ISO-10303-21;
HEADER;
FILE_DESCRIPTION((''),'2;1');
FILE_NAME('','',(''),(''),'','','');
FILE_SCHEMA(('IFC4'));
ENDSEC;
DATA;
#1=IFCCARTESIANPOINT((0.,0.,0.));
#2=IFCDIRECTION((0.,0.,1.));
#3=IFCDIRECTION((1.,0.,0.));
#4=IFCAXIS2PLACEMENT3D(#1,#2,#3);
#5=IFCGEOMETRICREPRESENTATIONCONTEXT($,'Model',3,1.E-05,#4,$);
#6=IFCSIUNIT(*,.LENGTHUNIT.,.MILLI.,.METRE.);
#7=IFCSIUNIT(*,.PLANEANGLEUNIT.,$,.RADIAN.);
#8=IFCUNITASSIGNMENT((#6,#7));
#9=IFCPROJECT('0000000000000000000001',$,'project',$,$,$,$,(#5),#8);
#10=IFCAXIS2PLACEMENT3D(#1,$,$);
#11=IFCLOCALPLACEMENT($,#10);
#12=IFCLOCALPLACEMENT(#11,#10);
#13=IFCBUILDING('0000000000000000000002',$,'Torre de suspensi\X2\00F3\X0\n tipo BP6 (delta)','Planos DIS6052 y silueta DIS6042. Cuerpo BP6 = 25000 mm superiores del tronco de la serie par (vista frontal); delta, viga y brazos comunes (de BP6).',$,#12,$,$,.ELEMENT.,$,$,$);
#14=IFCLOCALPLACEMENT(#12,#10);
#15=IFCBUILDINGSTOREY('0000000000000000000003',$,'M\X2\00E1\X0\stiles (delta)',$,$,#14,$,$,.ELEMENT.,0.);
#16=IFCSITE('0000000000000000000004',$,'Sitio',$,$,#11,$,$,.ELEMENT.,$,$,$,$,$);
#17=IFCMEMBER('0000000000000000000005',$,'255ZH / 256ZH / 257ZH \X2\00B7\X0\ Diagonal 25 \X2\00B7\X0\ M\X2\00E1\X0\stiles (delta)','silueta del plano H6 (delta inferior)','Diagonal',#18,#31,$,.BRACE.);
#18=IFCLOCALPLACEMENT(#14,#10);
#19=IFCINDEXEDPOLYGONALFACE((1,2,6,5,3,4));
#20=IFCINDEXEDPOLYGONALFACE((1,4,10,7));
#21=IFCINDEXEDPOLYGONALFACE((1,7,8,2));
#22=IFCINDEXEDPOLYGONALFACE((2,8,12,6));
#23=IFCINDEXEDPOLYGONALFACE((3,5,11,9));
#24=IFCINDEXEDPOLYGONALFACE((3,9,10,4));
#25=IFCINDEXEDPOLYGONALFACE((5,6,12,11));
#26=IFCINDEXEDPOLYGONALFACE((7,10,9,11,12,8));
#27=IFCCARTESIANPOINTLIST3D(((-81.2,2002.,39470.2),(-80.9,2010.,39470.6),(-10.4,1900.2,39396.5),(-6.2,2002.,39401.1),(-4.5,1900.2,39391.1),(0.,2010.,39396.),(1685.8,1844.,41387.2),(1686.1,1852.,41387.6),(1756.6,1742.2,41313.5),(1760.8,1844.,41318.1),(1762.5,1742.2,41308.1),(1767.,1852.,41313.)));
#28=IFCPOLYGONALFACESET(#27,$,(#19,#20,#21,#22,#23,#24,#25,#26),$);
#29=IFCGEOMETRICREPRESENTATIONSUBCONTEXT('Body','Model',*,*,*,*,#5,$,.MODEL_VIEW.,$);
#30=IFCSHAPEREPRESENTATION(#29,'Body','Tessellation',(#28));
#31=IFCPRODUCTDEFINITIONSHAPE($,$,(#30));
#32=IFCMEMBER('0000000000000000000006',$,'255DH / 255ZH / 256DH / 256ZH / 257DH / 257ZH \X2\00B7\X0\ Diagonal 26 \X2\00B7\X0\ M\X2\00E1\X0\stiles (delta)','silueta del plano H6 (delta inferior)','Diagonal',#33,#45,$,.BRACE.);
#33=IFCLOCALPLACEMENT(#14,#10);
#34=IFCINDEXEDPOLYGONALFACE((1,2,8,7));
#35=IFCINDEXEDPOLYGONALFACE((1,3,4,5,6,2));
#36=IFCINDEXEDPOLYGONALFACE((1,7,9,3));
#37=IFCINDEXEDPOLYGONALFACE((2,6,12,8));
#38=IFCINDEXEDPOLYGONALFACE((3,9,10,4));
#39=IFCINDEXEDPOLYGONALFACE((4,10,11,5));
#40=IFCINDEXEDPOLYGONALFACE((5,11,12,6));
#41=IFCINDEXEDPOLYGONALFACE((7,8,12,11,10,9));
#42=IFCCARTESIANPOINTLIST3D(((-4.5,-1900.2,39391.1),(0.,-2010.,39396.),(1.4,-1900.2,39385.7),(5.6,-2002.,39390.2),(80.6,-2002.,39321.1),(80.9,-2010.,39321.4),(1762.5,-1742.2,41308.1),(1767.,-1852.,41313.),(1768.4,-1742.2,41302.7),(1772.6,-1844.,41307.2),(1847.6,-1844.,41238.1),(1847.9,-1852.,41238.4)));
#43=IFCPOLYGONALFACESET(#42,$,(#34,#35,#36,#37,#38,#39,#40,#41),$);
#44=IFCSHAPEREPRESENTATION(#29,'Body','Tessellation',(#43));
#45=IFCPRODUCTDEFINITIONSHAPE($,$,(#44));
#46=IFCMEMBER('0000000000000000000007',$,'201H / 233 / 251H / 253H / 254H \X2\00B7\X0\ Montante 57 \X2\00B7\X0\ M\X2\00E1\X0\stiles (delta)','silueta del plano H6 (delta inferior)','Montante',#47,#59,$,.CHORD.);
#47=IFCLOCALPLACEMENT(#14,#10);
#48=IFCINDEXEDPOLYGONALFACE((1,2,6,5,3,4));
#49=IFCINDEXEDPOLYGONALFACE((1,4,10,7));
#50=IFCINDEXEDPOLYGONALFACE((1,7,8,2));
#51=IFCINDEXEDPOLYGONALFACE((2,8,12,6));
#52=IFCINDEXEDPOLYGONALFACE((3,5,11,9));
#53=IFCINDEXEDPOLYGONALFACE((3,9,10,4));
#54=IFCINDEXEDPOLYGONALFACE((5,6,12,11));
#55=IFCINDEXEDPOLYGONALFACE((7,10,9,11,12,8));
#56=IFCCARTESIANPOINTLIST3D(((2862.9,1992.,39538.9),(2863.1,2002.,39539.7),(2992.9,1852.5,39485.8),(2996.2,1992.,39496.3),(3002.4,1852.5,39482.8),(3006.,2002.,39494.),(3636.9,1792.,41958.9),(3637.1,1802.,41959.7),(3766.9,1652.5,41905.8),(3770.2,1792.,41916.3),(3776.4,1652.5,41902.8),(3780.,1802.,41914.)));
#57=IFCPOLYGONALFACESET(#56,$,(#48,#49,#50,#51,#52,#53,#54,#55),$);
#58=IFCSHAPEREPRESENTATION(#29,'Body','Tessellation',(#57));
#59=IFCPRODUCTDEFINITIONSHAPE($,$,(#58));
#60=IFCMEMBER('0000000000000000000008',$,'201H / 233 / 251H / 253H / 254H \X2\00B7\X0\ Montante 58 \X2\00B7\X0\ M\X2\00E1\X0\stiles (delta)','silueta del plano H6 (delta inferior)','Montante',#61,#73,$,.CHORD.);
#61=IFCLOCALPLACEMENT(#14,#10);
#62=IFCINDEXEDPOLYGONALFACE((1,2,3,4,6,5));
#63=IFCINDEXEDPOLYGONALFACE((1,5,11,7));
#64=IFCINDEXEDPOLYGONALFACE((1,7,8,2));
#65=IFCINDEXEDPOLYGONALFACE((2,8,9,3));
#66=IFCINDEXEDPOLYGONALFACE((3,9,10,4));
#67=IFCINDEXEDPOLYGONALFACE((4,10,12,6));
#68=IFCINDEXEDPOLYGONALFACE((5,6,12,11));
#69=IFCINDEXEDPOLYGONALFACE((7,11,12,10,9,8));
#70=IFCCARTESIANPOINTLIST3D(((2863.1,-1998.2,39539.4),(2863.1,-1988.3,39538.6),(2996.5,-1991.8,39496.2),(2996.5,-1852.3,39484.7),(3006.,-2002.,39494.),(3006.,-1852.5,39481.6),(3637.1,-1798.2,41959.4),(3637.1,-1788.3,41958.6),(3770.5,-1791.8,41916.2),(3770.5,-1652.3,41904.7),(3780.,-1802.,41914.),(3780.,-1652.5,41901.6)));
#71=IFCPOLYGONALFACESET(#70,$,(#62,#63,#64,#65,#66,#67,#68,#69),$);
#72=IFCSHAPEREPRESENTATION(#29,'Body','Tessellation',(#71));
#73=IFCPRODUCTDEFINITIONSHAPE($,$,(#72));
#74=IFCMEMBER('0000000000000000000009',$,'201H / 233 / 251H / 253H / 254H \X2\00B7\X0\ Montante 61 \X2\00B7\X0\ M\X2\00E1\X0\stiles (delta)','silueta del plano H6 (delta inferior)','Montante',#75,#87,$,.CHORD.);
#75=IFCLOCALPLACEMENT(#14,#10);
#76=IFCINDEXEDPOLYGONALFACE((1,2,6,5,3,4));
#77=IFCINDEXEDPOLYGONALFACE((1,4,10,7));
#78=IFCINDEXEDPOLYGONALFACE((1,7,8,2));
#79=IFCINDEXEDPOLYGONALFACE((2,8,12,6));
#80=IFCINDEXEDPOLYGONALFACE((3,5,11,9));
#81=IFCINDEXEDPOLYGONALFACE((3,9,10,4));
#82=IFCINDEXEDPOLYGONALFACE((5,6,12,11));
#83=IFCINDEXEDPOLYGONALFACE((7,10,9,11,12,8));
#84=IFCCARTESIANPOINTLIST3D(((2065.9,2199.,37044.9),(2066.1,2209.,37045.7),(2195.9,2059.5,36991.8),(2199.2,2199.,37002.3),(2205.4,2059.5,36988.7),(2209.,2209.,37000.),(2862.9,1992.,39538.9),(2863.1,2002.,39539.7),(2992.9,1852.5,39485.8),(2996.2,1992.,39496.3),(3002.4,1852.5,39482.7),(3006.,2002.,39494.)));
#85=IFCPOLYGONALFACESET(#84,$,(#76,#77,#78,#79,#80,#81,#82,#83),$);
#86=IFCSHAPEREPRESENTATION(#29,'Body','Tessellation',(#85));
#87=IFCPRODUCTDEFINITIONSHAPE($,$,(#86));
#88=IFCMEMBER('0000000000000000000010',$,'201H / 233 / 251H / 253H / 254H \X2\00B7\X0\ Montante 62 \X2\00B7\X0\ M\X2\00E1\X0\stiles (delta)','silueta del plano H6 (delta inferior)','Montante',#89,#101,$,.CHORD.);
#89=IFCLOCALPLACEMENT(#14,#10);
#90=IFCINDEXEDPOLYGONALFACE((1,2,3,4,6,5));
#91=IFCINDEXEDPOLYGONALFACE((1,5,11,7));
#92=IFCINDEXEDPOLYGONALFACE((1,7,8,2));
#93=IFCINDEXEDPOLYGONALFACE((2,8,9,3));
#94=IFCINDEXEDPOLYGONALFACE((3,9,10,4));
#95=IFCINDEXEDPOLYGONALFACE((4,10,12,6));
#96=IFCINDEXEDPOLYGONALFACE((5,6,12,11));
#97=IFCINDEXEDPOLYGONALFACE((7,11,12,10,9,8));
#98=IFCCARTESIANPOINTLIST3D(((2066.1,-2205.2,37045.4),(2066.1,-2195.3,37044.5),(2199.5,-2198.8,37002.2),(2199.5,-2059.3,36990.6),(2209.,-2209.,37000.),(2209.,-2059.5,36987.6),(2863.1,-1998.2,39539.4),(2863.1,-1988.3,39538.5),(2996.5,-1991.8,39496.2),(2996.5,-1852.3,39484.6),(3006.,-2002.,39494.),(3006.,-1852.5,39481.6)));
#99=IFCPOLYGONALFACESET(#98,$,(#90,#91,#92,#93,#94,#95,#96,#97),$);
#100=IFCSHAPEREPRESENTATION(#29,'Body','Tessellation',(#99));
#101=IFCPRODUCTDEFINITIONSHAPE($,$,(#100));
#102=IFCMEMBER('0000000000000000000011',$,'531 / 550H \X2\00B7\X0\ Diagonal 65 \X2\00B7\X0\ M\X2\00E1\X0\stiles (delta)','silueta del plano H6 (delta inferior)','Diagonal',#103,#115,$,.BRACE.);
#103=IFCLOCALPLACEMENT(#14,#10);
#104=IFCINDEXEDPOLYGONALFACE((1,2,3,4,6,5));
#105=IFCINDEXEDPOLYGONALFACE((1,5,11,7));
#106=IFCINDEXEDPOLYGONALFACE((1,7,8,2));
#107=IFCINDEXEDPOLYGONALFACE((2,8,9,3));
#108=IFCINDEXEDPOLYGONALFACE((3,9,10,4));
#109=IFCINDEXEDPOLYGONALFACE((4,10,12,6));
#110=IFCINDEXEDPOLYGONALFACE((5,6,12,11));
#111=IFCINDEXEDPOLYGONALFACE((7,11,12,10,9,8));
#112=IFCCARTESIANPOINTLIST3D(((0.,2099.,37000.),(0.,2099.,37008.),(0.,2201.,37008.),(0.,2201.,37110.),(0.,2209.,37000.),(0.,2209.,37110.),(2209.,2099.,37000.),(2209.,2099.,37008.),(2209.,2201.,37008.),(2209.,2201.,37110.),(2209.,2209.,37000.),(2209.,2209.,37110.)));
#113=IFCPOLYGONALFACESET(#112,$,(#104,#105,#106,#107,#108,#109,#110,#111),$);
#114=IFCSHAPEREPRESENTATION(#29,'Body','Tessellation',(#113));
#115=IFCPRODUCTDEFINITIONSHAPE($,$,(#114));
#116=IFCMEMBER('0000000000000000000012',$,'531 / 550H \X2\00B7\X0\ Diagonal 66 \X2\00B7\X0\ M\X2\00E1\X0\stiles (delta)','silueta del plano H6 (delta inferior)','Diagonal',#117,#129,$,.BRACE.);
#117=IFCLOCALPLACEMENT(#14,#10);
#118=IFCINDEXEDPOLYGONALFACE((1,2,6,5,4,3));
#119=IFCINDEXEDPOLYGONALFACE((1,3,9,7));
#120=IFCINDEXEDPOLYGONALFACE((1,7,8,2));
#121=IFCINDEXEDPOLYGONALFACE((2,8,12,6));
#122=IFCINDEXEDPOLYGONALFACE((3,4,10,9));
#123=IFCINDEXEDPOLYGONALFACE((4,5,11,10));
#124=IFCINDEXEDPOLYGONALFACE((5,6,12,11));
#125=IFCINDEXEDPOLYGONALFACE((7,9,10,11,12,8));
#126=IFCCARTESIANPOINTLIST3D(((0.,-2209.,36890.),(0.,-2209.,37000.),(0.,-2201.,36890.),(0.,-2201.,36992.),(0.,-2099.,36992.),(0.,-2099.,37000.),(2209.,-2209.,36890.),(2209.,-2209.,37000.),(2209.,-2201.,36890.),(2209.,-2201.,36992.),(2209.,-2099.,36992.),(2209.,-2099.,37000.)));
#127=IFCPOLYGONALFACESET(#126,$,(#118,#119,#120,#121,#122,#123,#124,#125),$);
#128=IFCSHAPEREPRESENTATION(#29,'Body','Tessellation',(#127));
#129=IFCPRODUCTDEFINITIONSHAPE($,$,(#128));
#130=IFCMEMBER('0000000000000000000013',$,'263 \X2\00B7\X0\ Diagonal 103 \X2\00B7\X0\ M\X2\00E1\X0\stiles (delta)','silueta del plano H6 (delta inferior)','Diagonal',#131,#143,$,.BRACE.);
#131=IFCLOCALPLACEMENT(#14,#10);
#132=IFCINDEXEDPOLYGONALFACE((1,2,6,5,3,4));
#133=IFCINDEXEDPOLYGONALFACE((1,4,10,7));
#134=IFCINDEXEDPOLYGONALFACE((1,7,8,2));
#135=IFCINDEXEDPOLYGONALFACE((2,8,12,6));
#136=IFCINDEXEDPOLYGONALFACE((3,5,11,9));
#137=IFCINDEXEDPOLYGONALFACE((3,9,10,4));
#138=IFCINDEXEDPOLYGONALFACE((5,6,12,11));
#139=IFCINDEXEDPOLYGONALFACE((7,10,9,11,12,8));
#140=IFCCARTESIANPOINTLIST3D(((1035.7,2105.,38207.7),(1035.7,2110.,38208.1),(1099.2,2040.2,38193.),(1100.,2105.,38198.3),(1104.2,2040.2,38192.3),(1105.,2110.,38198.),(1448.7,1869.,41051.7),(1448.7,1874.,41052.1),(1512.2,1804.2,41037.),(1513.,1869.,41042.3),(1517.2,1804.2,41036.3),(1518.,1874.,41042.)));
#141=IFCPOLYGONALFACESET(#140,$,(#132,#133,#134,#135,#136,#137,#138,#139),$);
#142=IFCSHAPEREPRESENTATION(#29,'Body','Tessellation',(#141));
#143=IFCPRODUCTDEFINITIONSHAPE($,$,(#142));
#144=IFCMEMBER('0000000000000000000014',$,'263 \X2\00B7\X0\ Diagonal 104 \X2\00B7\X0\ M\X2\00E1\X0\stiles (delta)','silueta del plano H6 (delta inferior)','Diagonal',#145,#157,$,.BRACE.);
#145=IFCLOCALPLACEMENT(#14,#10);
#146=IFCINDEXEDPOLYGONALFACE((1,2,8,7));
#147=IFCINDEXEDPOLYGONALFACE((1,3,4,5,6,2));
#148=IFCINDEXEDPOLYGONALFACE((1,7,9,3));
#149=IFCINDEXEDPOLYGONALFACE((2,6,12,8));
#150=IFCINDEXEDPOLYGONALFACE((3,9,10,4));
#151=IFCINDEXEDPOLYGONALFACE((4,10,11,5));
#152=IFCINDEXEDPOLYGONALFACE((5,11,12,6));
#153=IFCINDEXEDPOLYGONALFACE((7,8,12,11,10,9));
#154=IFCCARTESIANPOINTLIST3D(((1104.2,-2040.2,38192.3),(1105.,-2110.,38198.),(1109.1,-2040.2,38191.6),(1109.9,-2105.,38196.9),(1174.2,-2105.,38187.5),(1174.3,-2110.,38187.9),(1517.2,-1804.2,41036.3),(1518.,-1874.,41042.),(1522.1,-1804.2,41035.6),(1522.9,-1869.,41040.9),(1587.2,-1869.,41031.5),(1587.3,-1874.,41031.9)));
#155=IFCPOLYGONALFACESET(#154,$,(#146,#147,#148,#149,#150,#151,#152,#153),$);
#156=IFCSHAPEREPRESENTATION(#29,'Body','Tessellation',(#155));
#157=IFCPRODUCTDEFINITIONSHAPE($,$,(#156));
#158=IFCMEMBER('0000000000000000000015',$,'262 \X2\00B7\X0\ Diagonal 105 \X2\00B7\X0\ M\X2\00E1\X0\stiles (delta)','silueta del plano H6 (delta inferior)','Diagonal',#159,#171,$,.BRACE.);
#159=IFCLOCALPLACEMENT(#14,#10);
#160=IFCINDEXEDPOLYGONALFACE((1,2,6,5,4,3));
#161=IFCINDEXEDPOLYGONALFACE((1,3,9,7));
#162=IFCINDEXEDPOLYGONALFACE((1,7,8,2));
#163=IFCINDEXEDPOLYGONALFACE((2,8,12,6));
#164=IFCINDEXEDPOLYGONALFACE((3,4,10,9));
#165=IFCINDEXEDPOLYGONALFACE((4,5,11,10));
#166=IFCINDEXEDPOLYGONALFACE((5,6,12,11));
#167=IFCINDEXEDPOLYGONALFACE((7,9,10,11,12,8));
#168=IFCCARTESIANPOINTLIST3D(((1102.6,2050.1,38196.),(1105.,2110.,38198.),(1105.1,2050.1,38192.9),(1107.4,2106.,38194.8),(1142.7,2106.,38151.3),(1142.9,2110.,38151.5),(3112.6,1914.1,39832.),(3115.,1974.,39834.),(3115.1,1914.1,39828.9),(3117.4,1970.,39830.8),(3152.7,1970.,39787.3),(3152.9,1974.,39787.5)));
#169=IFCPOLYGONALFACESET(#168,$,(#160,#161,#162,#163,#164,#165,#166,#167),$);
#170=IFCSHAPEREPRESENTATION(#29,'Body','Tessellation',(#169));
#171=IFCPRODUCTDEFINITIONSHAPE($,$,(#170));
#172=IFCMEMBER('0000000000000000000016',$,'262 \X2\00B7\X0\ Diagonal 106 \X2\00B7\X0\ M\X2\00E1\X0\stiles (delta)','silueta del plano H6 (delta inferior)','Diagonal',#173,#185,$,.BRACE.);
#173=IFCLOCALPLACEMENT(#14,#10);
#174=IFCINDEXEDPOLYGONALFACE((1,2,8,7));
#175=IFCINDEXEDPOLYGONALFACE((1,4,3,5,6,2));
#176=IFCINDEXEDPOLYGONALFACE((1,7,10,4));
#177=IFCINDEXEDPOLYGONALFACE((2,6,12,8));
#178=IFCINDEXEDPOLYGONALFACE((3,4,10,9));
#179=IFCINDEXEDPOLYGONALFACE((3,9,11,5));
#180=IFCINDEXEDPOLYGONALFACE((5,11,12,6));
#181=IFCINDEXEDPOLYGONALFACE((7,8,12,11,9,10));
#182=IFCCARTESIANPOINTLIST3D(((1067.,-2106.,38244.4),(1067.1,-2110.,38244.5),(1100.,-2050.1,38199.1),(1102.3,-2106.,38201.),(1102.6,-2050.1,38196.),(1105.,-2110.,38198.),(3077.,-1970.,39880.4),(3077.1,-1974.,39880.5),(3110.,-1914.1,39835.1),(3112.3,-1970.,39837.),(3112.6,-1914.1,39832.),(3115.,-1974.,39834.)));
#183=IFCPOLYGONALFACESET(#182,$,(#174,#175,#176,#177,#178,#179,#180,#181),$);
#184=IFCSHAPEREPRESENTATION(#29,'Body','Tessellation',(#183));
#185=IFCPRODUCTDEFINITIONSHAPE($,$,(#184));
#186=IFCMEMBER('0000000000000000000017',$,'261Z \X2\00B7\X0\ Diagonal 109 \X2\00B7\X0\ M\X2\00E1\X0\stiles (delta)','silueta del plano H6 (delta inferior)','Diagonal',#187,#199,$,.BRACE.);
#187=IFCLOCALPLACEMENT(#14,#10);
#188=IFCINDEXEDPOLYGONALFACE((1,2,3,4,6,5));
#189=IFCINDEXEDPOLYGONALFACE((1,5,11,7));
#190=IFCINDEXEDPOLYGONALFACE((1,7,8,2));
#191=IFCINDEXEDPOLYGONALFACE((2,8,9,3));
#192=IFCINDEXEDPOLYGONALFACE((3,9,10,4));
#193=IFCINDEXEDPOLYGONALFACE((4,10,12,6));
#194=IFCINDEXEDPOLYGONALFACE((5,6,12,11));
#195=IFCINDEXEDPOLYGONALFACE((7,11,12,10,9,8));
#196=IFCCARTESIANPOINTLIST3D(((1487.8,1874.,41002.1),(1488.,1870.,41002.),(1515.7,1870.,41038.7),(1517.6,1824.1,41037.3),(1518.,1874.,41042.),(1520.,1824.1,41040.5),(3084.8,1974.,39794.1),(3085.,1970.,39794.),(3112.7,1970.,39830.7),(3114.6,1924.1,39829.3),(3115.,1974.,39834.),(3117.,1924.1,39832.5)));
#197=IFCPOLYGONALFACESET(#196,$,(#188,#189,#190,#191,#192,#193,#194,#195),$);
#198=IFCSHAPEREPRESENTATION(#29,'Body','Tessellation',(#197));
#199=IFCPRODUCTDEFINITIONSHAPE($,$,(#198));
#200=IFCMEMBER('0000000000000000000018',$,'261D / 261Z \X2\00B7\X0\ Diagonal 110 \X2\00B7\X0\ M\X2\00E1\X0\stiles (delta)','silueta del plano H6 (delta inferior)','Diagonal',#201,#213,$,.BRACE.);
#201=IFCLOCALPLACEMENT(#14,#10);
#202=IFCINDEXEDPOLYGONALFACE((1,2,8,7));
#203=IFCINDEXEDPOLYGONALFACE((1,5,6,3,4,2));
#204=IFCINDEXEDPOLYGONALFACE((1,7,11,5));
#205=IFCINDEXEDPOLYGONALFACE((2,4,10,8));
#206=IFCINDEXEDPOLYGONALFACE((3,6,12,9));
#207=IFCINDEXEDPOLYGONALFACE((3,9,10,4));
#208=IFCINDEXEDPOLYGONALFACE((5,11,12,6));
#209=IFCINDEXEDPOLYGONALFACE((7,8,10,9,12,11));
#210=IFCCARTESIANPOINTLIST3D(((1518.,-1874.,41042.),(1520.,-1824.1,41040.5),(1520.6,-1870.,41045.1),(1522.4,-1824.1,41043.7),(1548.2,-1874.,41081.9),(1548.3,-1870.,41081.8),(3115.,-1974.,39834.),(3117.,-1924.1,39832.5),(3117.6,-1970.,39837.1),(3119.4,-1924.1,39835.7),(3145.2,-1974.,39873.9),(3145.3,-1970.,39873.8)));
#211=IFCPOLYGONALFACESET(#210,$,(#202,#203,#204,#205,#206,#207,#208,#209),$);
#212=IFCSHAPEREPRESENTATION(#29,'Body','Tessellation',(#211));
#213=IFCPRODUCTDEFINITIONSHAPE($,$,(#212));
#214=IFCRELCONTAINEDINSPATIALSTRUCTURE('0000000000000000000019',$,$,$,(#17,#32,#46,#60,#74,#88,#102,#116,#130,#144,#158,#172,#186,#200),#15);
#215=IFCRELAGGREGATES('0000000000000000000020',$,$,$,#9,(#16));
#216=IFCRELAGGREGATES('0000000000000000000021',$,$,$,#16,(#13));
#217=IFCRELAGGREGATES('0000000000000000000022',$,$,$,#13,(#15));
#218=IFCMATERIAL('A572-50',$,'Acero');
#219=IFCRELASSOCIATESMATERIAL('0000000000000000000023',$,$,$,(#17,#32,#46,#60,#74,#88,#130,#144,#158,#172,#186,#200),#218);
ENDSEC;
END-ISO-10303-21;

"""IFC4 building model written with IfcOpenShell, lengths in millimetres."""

from ifc_helpers import new_model, si_unit, frame, frame_2d, origin, origin_with_axes, place, context, subcontext, project, spatial, l_section, extrude, material, element, save


model = new_model("IFC4")

# Units and contexts
model_context = context("Model", 3, precision=1e-05, world=origin_with_axes())
body_context = subcontext(model_context, "Body", "Model", "MODEL_VIEW")
ifc_project = project(units=[si_unit("LENGTHUNIT", "METRE", prefix="MILLI"), si_unit("PLANEANGLEUNIT", "RADIAN")], contexts=[model_context])

# Site, building, storey
site_placement = place(None, origin())
site = spatial("IfcSite", under=ifc_project, at=site_placement, Name="Sitio", CompositionType="ELEMENT")
building_placement = place(site_placement, origin())
building = spatial("IfcBuilding", under=site, at=building_placement, Name="Torre de suspensión tipo BP6 (delta)", Description="Planos DIS6052 y silueta DIS6042. Cuerpo BP6 = 25000 mm superiores del tronco de la serie par (vista frontal); delta, viga y brazos comunes (de BP6).", CompositionType="ELEMENT")
storey_placement = place(building_placement, origin())
storey = spatial("IfcBuildingStorey", under=building, at=storey_placement, Name="Mástiles (delta)", CompositionType="ELEMENT", Elevation=0.0)

# Members
ifc_material_1 = material(Name="A572-50", Category="Acero")
for number, where, z_axis, x_axis, name in (
    (1, (1767.0, 1852.0, 41313.0), (-0.676513, 0.060492, -0.733942), (-0.040999, -0.998169, -0.044479), "255ZH / 256ZH / 257ZH · Diagonal 25 · Mástiles (delta)"),
    (2, (1767.0, -1852.0, 41313.0), (-0.676513, -0.060492, -0.733942), (-0.040999, 0.998169, -0.044479), "255DH / 255ZH / 256DH / 256ZH / 257DH / 257ZH · Diagonal 26 · Mástiles (delta)"),
):
    element("IfcMember", number, at=place(storey_placement, frame(where, z_axis=z_axis, x_axis=x_axis)), inside=storey, material=ifc_material_1, Name=name, Description="silueta del plano H6 (delta inferior)", ObjectType="Diagonal", PredefinedType="BRACE", context=body_context, shape_type="SweptSolid", body=[
        extrude(l_section(Depth=110.0, Width=110.0, Thickness=8.0, at=frame_2d((55.0, 55.0))), None, (0.0, 0.0, 1.0), 2611.9),
    ])
for number, where, z_axis, x_axis, name in (
    (3, (3780.0, 1802.0, 41914.0), (-0.303693, 0.078474, -0.949533), (-0.023906, -0.996916, -0.074744), "201H / 233 / 251H / 253H / 254H · Montante 57 · Mástiles (delta)"),
    (4, (3780.0, -1802.0, 41914.0), (-0.303693, -0.078474, -0.949533), (-0.95277, 0.025013, 0.302662), "201H / 233 / 251H / 253H / 254H · Montante 58 · Mástiles (delta)"),
):
    element("IfcMember", number, at=place(storey_placement, frame(where, z_axis=z_axis, x_axis=x_axis)), inside=storey, material=ifc_material_1, Name=name, Description="silueta del plano H6 (delta inferior)", ObjectType="Montante", PredefinedType="CHORD", context=body_context, shape_type="SweptSolid", body=[
        extrude(l_section(Depth=150.0, Width=150.0, Thickness=10.0, at=frame_2d((75.0, 75.0))), None, (0.0, 0.0, 1.0), 2548.6),
    ])
for number, where, z_axis, x_axis, name in (
    (5, (3006.0, 2002.0, 39494.0), (-0.303455, 0.078814, -0.949581), (-0.023991, -0.996889, -0.075074), "201H / 233 / 251H / 253H / 254H · Montante 61 · Mástiles (delta)"),
    (6, (3006.0, -2002.0, 39494.0), (-0.303455, -0.078814, -0.949581), (-0.952846, 0.0251, 0.302415), "201H / 233 / 251H / 253H / 254H · Montante 62 · Mástiles (delta)"),
):
    element("IfcMember", number, at=place(storey_placement, frame(where, z_axis=z_axis, x_axis=x_axis)), inside=storey, material=ifc_material_1, Name=name, Description="silueta del plano H6 (delta inferior)", ObjectType="Montante", PredefinedType="CHORD", context=body_context, shape_type="SweptSolid", body=[
        extrude(l_section(Depth=150.0, Width=150.0, Thickness=10.0, at=frame_2d((75.0, 75.0))), None, (0.0, 0.0, 1.0), 2626.4),
    ])
for number, where, z_axis, x_axis, name in (
    (7, (2209.0, 2209.0, 37000.0), (-1.0, 0.0, 0.0), (0.0, -1.0, 0.0), "531 / 550H · Diagonal 65 · Mástiles (delta)"),
    (8, (2209.0, -2209.0, 37000.0), (-1.0, 0.0, 0.0), (0.0, 1.0, 0.0), "531 / 550H · Diagonal 66 · Mástiles (delta)"),
):
    element("IfcMember", number, at=place(storey_placement, frame(where, z_axis=z_axis, x_axis=x_axis)), inside=storey, Name=name, Description="silueta del plano H6 (delta inferior)", ObjectType="Diagonal", PredefinedType="BRACE", context=body_context, shape_type="SweptSolid", body=[
        extrude(l_section(Depth=110.0, Width=110.0, Thickness=8.0, at=frame_2d((55.0, 55.0))), None, (0.0, 0.0, 1.0), 2209.0),
    ])
for number, where, z_axis, x_axis, name in (
    (9, (1518.0, 1874.0, 41042.0), (-0.143228, 0.081845, -0.9863), (-0.011762, -0.996645, -0.080995), "263 · Diagonal 103 · Mástiles (delta)"),
    (10, (1518.0, -1874.0, 41042.0), (-0.143228, -0.081845, -0.9863), (-0.011762, 0.996645, -0.080995), "263 · Diagonal 104 · Mástiles (delta)"),
):
    element("IfcMember", number, at=place(storey_placement, frame(where, z_axis=z_axis, x_axis=x_axis)), inside=storey, material=ifc_material_1, Name=name, Description="silueta del plano H6 (delta inferior)", ObjectType="Diagonal", PredefinedType="BRACE", context=body_context, shape_type="SweptSolid", body=[
        extrude(l_section(Depth=70.0, Width=70.0, Thickness=5.0, at=frame_2d((35.0, 35.0))), None, (0.0, 0.0, 1.0), 2883.5),
    ])
for number, where, z_axis, x_axis, name in (
    (11, (1105.0, 2110.0, 38198.0), (0.774505, -0.052404, 0.630393), (-0.040643, -0.998626, -0.033081), "262 · Diagonal 105 · Mástiles (delta)"),
    (12, (1105.0, -2110.0, 38198.0), (0.774505, 0.052404, 0.630393), (-0.040643, 0.998626, -0.033081), "262 · Diagonal 106 · Mástiles (delta)"),
):
    element("IfcMember", number, at=place(storey_placement, frame(where, z_axis=z_axis, x_axis=x_axis)), inside=storey, material=ifc_material_1, Name=name, Description="silueta del plano H6 (delta inferior)", ObjectType="Diagonal", PredefinedType="BRACE", context=body_context, shape_type="SweptSolid", body=[
        extrude(l_section(Depth=60.0, Width=60.0, Thickness=4.0, at=frame_2d((30.0, 30.0))), None, (0.0, 0.0, 1.0), 2595.2),
    ])
for number, where, z_axis, x_axis, name in (
    (13, (1518.0, 1874.0, 41042.0), (0.796544, 0.049877, -0.60252), (0.039779, -0.998755, -0.03009), "261Z · Diagonal 109 · Mástiles (delta)"),
    (14, (1518.0, -1874.0, 41042.0), (0.796544, -0.049877, -0.60252), (0.039779, 0.998755, -0.03009), "261D / 261Z · Diagonal 110 · Mástiles (delta)"),
):
    element("IfcMember", number, at=place(storey_placement, frame(where, z_axis=z_axis, x_axis=x_axis)), inside=storey, material=ifc_material_1, Name=name, Description="silueta del plano H6 (delta inferior)", ObjectType="Diagonal", PredefinedType="BRACE", context=body_context, shape_type="SweptSolid", body=[
        extrude(l_section(Depth=50.0, Width=50.0, Thickness=4.0, at=frame_2d((25.0, 25.0))), None, (0.0, 0.0, 1.0), 2004.9),
    ])

save(model, "model.ifc")
